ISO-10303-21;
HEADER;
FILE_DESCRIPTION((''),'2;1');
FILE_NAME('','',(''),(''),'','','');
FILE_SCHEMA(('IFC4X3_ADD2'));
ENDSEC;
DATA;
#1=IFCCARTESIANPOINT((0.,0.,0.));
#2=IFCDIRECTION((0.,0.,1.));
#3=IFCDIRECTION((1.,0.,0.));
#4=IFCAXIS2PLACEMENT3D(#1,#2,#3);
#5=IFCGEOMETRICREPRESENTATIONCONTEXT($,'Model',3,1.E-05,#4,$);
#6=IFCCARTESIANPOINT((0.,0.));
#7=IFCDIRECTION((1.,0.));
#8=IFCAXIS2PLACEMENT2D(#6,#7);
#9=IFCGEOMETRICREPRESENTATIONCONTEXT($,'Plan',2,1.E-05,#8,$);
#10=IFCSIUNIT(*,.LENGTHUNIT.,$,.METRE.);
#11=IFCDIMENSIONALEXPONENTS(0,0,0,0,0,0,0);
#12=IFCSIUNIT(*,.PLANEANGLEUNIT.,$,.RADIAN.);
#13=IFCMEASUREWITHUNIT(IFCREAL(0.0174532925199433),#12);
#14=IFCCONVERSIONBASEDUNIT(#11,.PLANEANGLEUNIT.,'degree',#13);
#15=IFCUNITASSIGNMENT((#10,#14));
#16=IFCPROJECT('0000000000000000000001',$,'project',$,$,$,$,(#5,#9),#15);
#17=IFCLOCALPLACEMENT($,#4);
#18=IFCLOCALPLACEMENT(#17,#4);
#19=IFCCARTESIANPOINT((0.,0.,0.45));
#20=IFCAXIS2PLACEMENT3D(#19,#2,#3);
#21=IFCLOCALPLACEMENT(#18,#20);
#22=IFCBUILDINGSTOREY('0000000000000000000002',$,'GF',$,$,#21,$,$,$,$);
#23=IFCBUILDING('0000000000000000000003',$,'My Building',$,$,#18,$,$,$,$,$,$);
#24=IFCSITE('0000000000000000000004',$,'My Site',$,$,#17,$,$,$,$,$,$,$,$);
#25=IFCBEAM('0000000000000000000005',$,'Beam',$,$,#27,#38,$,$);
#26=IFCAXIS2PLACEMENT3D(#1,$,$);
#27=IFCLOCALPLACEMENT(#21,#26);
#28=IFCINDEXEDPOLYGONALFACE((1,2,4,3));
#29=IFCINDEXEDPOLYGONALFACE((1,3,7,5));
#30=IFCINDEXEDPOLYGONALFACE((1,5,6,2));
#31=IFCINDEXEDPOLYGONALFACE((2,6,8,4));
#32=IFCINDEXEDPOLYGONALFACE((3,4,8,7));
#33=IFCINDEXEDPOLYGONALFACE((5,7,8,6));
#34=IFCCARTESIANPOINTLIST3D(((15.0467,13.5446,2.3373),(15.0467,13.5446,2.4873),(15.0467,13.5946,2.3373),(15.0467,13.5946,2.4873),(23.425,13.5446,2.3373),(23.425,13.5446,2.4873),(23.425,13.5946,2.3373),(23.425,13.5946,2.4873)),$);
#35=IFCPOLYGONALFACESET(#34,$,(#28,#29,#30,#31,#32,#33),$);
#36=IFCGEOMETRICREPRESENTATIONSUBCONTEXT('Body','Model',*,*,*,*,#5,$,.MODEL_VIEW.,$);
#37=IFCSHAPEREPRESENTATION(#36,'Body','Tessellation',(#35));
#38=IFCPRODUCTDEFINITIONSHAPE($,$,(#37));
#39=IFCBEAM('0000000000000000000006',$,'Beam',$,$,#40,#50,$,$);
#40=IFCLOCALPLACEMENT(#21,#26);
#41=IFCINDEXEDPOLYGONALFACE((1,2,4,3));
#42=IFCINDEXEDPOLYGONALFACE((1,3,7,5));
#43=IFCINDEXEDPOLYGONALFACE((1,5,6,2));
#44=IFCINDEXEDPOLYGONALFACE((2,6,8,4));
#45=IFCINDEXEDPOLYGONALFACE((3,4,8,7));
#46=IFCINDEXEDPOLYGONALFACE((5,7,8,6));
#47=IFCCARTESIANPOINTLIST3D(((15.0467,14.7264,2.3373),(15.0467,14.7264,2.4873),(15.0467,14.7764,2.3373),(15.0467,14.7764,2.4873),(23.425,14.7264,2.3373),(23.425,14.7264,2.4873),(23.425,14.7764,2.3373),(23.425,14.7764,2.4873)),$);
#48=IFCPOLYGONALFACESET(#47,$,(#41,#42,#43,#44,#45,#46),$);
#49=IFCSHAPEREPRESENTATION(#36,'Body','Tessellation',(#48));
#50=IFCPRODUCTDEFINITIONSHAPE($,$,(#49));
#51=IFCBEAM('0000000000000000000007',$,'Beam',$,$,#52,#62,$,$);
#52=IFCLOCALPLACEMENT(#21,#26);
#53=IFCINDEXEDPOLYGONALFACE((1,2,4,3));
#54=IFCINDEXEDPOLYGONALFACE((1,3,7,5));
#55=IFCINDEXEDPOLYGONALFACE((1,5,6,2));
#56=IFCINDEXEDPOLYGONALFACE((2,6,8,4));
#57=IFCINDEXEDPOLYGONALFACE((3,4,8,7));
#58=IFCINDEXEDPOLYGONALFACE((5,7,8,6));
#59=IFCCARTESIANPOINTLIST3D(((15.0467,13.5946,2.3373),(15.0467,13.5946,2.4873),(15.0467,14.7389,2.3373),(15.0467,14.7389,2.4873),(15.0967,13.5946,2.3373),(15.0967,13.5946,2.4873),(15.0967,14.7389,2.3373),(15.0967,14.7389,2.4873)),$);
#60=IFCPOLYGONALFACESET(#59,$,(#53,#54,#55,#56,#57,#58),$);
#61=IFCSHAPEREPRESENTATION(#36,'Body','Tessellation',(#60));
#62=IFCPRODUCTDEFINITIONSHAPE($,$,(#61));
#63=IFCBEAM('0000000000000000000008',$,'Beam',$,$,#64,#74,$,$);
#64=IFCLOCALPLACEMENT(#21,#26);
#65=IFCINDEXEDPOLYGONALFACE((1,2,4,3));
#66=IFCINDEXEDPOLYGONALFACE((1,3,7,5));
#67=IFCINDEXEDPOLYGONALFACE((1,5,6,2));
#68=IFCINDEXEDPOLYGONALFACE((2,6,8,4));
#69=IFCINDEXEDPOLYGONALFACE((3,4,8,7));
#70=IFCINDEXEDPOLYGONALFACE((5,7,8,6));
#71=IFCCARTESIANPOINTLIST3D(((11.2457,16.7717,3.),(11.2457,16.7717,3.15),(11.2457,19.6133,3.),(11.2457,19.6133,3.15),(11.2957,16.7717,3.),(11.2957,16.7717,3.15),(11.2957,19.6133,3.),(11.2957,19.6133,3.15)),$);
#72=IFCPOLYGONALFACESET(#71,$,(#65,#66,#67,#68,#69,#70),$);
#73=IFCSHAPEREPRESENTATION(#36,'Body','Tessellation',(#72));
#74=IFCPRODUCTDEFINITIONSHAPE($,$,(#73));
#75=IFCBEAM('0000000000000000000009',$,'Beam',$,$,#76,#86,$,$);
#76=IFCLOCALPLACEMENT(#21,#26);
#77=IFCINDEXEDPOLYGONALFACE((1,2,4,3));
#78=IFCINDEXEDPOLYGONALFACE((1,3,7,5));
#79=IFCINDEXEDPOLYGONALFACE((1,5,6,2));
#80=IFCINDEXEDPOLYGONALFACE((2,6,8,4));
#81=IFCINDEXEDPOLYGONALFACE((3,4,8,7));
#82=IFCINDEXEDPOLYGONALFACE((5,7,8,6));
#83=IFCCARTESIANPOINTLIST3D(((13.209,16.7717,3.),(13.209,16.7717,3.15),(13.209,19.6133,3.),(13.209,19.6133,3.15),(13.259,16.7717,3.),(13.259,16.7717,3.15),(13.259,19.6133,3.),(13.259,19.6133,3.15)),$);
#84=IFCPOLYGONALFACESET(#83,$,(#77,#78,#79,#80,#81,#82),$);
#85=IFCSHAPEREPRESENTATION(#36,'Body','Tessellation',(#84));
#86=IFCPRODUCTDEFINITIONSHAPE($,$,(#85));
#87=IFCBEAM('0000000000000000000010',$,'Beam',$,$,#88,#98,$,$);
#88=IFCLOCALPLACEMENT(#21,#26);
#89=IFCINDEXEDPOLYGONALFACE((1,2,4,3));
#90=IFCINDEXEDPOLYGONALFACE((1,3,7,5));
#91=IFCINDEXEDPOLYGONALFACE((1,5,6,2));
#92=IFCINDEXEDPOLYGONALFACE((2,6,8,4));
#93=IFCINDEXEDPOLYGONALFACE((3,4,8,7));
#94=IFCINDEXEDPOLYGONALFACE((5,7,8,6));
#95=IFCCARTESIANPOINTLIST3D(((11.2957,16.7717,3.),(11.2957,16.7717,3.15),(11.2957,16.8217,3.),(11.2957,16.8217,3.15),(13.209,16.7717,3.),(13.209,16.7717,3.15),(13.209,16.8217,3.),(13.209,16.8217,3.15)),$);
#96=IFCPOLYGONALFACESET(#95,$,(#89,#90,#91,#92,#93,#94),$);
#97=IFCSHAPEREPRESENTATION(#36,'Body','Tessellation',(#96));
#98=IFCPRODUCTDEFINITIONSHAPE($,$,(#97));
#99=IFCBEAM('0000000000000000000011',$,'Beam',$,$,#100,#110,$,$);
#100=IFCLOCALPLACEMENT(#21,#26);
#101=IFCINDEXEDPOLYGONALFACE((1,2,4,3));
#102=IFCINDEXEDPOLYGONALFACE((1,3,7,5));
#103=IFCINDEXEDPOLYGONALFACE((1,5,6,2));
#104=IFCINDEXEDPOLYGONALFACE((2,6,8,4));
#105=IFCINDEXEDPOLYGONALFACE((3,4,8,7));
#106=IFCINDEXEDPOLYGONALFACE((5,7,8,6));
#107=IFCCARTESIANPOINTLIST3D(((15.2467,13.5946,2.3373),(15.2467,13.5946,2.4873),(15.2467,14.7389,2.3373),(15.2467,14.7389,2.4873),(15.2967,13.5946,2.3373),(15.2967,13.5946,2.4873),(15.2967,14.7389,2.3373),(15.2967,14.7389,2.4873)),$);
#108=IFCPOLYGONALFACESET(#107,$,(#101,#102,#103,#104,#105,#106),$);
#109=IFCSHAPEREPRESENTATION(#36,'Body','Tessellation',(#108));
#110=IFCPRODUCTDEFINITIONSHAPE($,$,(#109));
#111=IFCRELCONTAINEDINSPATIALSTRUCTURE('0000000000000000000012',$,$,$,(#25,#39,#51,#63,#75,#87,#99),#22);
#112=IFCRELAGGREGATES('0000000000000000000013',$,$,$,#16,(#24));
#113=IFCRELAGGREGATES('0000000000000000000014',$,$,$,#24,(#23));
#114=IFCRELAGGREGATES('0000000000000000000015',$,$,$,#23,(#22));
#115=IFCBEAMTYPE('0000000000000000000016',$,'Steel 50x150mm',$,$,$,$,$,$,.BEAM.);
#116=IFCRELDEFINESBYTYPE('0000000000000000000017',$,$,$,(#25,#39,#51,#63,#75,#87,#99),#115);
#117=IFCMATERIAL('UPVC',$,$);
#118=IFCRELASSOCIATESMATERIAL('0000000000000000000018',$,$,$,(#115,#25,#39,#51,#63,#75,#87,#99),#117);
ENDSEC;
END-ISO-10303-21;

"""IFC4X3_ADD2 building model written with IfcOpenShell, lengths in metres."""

from ifc_helpers import new_model, entity, si_unit, converted_unit, frame, origin_with_axes, origin_2d_with_axis, place, context, subcontext, project, spatial, rectangle, extrude, material, material_profile, profile_set, profile_usage, type_object, element, save


model = new_model("IFC4X3_ADD2")

# Units and contexts
model_context = context("Model", 3, precision=1e-05, world=origin_with_axes())
plan_context = context("Plan", 2, precision=1e-05, world=origin_2d_with_axis())
body_context_1 = subcontext(model_context, "Body", "Model", "MODEL_VIEW")
ifc_project = project(units=[si_unit("LENGTHUNIT", "METRE"), converted_unit("PLANEANGLEUNIT", "degree", entity("IfcReal", 0.0174532925199433), si_unit("PLANEANGLEUNIT", "RADIAN"), dimensions=[0, 0, 0, 0, 0, 0, 0])], contexts=[model_context, plan_context])

# Site, building, storey
site_placement = place(None, origin_with_axes())
site = spatial("IfcSite", under=ifc_project, at=site_placement, Name="My Site")
building_placement = place(site_placement, origin_with_axes())
building = spatial("IfcBuilding", under=site, at=building_placement, Name="My Building")
storey_placement = place(building_placement, frame((0.0, 0.0, 0.45), z_axis=(0.0, 0.0, 1.0), x_axis=(1.0, 0.0, 0.0)))
storey = spatial("IfcBuildingStorey", under=building, at=storey_placement, Name="GF")

# Beams
ifc_material_1 = material(Name="UPVC")
ifc_material_profile = material_profile(ifc_material_1, rectangle(XDim=0.05, YDim=0.15))
ifc_profile_set = profile_set([ifc_material_profile])
ifc_profile_usage_1 = profile_usage(ifc_profile_set)
beam_type = type_object("IfcBeamType", Name="Steel 50x150mm", PredefinedType="BEAM", material=ifc_profile_set)
beam_1_placement = place(storey_placement, frame((15.0467, 13.5696, 2.4123), z_axis=(1.0, 0.0, 0.0), x_axis=(0.0, 1.0, 0.0)))
element("IfcBeam", 1, at=beam_1_placement, inside=storey, type_object=beam_type, material=ifc_profile_usage_1, Name="Beam", context=body_context_1, shape_type="SweptSolid", body=[
    extrude(rectangle(XDim=0.05, YDim=0.15), origin_with_axes(), (0.0, 0.0, 1.0), 8.3783),
])
ifc_profile_usage_2 = profile_usage(ifc_profile_set)
beam_2_placement = place(storey_placement, frame((15.0467, 14.7514, 2.4123), z_axis=(1.0, 0.0, 0.0), x_axis=(0.0, 1.0, 0.0)))
element("IfcBeam", 2, at=beam_2_placement, inside=storey, type_object=beam_type, material=ifc_profile_usage_2, Name="Beam", context=body_context_1, shape_type="SweptSolid", body=[
    extrude(rectangle(XDim=0.05, YDim=0.15), origin_with_axes(), (0.0, 0.0, 1.0), 8.3783),
])
ifc_profile_usage_3 = profile_usage(ifc_profile_set)
beam_3_placement = place(storey_placement, frame((15.0717, 14.7389, 2.4123), z_axis=(0.0, -1.0, 0.0), x_axis=(1.0, 0.0, 0.0)))
element("IfcBeam", 3, at=beam_3_placement, inside=storey, type_object=beam_type, material=ifc_profile_usage_3, Name="Beam", context=body_context_1, shape_type="SweptSolid", body=[
    extrude(rectangle(XDim=0.05, YDim=0.15), origin_with_axes(), (0.0, 0.0, 1.0), 1.1444),
])
ifc_profile_usage_4 = profile_usage(ifc_profile_set)
beam_4_placement = place(storey_placement, frame((11.2707, 16.7717, 3.075), z_axis=(0.0, 1.0, 0.0), x_axis=(-1.0, 0.0, 0.0)))
element("IfcBeam", 4, at=beam_4_placement, inside=storey, type_object=beam_type, material=ifc_profile_usage_4, Name="Beam", context=body_context_1, shape_type="SweptSolid", body=[
    extrude(rectangle(XDim=0.05, YDim=0.15), origin_with_axes(), (0.0, 0.0, 1.0), 2.8416),
])
ifc_profile_usage_5 = profile_usage(ifc_profile_set)
beam_5_placement = place(storey_placement, frame((13.234, 16.7717, 3.075), z_axis=(0.0, 1.0, 0.0), x_axis=(-1.0, 0.0, 0.0)))
element("IfcBeam", 5, at=beam_5_placement, inside=storey, type_object=beam_type, material=ifc_profile_usage_5, Name="Beam", context=body_context_1, shape_type="SweptSolid", body=[
    extrude(rectangle(XDim=0.05, YDim=0.15), origin_with_axes(), (0.0, 0.0, 1.0), 2.8416),
])
ifc_profile_usage_6 = profile_usage(ifc_profile_set)
beam_6_placement = place(storey_placement, frame((11.2957, 16.7967, 3.075), z_axis=(1.0, 0.0, 0.0), x_axis=(0.0, 1.0, 0.0)))
element("IfcBeam", 6, at=beam_6_placement, inside=storey, type_object=beam_type, material=ifc_profile_usage_6, Name="Beam", context=body_context_1, shape_type="SweptSolid", body=[
    extrude(rectangle(XDim=0.05, YDim=0.15), origin_with_axes(), (0.0, 0.0, 1.0), 1.9133),
])
ifc_profile_usage_7 = profile_usage(ifc_profile_set)
beam_7_placement = place(storey_placement, frame((15.2717, 14.7389, 2.4123), z_axis=(0.0, -1.0, 0.0), x_axis=(1.0, 0.0, 0.0)))
element("IfcBeam", 7, at=beam_7_placement, inside=storey, type_object=beam_type, material=ifc_profile_usage_7, Name="Beam", context=body_context_1, shape_type="SweptSolid", body=[
    extrude(rectangle(XDim=0.05, YDim=0.15), origin_with_axes(), (0.0, 0.0, 1.0), 1.1444),
])

save(model, "model.ifc")
